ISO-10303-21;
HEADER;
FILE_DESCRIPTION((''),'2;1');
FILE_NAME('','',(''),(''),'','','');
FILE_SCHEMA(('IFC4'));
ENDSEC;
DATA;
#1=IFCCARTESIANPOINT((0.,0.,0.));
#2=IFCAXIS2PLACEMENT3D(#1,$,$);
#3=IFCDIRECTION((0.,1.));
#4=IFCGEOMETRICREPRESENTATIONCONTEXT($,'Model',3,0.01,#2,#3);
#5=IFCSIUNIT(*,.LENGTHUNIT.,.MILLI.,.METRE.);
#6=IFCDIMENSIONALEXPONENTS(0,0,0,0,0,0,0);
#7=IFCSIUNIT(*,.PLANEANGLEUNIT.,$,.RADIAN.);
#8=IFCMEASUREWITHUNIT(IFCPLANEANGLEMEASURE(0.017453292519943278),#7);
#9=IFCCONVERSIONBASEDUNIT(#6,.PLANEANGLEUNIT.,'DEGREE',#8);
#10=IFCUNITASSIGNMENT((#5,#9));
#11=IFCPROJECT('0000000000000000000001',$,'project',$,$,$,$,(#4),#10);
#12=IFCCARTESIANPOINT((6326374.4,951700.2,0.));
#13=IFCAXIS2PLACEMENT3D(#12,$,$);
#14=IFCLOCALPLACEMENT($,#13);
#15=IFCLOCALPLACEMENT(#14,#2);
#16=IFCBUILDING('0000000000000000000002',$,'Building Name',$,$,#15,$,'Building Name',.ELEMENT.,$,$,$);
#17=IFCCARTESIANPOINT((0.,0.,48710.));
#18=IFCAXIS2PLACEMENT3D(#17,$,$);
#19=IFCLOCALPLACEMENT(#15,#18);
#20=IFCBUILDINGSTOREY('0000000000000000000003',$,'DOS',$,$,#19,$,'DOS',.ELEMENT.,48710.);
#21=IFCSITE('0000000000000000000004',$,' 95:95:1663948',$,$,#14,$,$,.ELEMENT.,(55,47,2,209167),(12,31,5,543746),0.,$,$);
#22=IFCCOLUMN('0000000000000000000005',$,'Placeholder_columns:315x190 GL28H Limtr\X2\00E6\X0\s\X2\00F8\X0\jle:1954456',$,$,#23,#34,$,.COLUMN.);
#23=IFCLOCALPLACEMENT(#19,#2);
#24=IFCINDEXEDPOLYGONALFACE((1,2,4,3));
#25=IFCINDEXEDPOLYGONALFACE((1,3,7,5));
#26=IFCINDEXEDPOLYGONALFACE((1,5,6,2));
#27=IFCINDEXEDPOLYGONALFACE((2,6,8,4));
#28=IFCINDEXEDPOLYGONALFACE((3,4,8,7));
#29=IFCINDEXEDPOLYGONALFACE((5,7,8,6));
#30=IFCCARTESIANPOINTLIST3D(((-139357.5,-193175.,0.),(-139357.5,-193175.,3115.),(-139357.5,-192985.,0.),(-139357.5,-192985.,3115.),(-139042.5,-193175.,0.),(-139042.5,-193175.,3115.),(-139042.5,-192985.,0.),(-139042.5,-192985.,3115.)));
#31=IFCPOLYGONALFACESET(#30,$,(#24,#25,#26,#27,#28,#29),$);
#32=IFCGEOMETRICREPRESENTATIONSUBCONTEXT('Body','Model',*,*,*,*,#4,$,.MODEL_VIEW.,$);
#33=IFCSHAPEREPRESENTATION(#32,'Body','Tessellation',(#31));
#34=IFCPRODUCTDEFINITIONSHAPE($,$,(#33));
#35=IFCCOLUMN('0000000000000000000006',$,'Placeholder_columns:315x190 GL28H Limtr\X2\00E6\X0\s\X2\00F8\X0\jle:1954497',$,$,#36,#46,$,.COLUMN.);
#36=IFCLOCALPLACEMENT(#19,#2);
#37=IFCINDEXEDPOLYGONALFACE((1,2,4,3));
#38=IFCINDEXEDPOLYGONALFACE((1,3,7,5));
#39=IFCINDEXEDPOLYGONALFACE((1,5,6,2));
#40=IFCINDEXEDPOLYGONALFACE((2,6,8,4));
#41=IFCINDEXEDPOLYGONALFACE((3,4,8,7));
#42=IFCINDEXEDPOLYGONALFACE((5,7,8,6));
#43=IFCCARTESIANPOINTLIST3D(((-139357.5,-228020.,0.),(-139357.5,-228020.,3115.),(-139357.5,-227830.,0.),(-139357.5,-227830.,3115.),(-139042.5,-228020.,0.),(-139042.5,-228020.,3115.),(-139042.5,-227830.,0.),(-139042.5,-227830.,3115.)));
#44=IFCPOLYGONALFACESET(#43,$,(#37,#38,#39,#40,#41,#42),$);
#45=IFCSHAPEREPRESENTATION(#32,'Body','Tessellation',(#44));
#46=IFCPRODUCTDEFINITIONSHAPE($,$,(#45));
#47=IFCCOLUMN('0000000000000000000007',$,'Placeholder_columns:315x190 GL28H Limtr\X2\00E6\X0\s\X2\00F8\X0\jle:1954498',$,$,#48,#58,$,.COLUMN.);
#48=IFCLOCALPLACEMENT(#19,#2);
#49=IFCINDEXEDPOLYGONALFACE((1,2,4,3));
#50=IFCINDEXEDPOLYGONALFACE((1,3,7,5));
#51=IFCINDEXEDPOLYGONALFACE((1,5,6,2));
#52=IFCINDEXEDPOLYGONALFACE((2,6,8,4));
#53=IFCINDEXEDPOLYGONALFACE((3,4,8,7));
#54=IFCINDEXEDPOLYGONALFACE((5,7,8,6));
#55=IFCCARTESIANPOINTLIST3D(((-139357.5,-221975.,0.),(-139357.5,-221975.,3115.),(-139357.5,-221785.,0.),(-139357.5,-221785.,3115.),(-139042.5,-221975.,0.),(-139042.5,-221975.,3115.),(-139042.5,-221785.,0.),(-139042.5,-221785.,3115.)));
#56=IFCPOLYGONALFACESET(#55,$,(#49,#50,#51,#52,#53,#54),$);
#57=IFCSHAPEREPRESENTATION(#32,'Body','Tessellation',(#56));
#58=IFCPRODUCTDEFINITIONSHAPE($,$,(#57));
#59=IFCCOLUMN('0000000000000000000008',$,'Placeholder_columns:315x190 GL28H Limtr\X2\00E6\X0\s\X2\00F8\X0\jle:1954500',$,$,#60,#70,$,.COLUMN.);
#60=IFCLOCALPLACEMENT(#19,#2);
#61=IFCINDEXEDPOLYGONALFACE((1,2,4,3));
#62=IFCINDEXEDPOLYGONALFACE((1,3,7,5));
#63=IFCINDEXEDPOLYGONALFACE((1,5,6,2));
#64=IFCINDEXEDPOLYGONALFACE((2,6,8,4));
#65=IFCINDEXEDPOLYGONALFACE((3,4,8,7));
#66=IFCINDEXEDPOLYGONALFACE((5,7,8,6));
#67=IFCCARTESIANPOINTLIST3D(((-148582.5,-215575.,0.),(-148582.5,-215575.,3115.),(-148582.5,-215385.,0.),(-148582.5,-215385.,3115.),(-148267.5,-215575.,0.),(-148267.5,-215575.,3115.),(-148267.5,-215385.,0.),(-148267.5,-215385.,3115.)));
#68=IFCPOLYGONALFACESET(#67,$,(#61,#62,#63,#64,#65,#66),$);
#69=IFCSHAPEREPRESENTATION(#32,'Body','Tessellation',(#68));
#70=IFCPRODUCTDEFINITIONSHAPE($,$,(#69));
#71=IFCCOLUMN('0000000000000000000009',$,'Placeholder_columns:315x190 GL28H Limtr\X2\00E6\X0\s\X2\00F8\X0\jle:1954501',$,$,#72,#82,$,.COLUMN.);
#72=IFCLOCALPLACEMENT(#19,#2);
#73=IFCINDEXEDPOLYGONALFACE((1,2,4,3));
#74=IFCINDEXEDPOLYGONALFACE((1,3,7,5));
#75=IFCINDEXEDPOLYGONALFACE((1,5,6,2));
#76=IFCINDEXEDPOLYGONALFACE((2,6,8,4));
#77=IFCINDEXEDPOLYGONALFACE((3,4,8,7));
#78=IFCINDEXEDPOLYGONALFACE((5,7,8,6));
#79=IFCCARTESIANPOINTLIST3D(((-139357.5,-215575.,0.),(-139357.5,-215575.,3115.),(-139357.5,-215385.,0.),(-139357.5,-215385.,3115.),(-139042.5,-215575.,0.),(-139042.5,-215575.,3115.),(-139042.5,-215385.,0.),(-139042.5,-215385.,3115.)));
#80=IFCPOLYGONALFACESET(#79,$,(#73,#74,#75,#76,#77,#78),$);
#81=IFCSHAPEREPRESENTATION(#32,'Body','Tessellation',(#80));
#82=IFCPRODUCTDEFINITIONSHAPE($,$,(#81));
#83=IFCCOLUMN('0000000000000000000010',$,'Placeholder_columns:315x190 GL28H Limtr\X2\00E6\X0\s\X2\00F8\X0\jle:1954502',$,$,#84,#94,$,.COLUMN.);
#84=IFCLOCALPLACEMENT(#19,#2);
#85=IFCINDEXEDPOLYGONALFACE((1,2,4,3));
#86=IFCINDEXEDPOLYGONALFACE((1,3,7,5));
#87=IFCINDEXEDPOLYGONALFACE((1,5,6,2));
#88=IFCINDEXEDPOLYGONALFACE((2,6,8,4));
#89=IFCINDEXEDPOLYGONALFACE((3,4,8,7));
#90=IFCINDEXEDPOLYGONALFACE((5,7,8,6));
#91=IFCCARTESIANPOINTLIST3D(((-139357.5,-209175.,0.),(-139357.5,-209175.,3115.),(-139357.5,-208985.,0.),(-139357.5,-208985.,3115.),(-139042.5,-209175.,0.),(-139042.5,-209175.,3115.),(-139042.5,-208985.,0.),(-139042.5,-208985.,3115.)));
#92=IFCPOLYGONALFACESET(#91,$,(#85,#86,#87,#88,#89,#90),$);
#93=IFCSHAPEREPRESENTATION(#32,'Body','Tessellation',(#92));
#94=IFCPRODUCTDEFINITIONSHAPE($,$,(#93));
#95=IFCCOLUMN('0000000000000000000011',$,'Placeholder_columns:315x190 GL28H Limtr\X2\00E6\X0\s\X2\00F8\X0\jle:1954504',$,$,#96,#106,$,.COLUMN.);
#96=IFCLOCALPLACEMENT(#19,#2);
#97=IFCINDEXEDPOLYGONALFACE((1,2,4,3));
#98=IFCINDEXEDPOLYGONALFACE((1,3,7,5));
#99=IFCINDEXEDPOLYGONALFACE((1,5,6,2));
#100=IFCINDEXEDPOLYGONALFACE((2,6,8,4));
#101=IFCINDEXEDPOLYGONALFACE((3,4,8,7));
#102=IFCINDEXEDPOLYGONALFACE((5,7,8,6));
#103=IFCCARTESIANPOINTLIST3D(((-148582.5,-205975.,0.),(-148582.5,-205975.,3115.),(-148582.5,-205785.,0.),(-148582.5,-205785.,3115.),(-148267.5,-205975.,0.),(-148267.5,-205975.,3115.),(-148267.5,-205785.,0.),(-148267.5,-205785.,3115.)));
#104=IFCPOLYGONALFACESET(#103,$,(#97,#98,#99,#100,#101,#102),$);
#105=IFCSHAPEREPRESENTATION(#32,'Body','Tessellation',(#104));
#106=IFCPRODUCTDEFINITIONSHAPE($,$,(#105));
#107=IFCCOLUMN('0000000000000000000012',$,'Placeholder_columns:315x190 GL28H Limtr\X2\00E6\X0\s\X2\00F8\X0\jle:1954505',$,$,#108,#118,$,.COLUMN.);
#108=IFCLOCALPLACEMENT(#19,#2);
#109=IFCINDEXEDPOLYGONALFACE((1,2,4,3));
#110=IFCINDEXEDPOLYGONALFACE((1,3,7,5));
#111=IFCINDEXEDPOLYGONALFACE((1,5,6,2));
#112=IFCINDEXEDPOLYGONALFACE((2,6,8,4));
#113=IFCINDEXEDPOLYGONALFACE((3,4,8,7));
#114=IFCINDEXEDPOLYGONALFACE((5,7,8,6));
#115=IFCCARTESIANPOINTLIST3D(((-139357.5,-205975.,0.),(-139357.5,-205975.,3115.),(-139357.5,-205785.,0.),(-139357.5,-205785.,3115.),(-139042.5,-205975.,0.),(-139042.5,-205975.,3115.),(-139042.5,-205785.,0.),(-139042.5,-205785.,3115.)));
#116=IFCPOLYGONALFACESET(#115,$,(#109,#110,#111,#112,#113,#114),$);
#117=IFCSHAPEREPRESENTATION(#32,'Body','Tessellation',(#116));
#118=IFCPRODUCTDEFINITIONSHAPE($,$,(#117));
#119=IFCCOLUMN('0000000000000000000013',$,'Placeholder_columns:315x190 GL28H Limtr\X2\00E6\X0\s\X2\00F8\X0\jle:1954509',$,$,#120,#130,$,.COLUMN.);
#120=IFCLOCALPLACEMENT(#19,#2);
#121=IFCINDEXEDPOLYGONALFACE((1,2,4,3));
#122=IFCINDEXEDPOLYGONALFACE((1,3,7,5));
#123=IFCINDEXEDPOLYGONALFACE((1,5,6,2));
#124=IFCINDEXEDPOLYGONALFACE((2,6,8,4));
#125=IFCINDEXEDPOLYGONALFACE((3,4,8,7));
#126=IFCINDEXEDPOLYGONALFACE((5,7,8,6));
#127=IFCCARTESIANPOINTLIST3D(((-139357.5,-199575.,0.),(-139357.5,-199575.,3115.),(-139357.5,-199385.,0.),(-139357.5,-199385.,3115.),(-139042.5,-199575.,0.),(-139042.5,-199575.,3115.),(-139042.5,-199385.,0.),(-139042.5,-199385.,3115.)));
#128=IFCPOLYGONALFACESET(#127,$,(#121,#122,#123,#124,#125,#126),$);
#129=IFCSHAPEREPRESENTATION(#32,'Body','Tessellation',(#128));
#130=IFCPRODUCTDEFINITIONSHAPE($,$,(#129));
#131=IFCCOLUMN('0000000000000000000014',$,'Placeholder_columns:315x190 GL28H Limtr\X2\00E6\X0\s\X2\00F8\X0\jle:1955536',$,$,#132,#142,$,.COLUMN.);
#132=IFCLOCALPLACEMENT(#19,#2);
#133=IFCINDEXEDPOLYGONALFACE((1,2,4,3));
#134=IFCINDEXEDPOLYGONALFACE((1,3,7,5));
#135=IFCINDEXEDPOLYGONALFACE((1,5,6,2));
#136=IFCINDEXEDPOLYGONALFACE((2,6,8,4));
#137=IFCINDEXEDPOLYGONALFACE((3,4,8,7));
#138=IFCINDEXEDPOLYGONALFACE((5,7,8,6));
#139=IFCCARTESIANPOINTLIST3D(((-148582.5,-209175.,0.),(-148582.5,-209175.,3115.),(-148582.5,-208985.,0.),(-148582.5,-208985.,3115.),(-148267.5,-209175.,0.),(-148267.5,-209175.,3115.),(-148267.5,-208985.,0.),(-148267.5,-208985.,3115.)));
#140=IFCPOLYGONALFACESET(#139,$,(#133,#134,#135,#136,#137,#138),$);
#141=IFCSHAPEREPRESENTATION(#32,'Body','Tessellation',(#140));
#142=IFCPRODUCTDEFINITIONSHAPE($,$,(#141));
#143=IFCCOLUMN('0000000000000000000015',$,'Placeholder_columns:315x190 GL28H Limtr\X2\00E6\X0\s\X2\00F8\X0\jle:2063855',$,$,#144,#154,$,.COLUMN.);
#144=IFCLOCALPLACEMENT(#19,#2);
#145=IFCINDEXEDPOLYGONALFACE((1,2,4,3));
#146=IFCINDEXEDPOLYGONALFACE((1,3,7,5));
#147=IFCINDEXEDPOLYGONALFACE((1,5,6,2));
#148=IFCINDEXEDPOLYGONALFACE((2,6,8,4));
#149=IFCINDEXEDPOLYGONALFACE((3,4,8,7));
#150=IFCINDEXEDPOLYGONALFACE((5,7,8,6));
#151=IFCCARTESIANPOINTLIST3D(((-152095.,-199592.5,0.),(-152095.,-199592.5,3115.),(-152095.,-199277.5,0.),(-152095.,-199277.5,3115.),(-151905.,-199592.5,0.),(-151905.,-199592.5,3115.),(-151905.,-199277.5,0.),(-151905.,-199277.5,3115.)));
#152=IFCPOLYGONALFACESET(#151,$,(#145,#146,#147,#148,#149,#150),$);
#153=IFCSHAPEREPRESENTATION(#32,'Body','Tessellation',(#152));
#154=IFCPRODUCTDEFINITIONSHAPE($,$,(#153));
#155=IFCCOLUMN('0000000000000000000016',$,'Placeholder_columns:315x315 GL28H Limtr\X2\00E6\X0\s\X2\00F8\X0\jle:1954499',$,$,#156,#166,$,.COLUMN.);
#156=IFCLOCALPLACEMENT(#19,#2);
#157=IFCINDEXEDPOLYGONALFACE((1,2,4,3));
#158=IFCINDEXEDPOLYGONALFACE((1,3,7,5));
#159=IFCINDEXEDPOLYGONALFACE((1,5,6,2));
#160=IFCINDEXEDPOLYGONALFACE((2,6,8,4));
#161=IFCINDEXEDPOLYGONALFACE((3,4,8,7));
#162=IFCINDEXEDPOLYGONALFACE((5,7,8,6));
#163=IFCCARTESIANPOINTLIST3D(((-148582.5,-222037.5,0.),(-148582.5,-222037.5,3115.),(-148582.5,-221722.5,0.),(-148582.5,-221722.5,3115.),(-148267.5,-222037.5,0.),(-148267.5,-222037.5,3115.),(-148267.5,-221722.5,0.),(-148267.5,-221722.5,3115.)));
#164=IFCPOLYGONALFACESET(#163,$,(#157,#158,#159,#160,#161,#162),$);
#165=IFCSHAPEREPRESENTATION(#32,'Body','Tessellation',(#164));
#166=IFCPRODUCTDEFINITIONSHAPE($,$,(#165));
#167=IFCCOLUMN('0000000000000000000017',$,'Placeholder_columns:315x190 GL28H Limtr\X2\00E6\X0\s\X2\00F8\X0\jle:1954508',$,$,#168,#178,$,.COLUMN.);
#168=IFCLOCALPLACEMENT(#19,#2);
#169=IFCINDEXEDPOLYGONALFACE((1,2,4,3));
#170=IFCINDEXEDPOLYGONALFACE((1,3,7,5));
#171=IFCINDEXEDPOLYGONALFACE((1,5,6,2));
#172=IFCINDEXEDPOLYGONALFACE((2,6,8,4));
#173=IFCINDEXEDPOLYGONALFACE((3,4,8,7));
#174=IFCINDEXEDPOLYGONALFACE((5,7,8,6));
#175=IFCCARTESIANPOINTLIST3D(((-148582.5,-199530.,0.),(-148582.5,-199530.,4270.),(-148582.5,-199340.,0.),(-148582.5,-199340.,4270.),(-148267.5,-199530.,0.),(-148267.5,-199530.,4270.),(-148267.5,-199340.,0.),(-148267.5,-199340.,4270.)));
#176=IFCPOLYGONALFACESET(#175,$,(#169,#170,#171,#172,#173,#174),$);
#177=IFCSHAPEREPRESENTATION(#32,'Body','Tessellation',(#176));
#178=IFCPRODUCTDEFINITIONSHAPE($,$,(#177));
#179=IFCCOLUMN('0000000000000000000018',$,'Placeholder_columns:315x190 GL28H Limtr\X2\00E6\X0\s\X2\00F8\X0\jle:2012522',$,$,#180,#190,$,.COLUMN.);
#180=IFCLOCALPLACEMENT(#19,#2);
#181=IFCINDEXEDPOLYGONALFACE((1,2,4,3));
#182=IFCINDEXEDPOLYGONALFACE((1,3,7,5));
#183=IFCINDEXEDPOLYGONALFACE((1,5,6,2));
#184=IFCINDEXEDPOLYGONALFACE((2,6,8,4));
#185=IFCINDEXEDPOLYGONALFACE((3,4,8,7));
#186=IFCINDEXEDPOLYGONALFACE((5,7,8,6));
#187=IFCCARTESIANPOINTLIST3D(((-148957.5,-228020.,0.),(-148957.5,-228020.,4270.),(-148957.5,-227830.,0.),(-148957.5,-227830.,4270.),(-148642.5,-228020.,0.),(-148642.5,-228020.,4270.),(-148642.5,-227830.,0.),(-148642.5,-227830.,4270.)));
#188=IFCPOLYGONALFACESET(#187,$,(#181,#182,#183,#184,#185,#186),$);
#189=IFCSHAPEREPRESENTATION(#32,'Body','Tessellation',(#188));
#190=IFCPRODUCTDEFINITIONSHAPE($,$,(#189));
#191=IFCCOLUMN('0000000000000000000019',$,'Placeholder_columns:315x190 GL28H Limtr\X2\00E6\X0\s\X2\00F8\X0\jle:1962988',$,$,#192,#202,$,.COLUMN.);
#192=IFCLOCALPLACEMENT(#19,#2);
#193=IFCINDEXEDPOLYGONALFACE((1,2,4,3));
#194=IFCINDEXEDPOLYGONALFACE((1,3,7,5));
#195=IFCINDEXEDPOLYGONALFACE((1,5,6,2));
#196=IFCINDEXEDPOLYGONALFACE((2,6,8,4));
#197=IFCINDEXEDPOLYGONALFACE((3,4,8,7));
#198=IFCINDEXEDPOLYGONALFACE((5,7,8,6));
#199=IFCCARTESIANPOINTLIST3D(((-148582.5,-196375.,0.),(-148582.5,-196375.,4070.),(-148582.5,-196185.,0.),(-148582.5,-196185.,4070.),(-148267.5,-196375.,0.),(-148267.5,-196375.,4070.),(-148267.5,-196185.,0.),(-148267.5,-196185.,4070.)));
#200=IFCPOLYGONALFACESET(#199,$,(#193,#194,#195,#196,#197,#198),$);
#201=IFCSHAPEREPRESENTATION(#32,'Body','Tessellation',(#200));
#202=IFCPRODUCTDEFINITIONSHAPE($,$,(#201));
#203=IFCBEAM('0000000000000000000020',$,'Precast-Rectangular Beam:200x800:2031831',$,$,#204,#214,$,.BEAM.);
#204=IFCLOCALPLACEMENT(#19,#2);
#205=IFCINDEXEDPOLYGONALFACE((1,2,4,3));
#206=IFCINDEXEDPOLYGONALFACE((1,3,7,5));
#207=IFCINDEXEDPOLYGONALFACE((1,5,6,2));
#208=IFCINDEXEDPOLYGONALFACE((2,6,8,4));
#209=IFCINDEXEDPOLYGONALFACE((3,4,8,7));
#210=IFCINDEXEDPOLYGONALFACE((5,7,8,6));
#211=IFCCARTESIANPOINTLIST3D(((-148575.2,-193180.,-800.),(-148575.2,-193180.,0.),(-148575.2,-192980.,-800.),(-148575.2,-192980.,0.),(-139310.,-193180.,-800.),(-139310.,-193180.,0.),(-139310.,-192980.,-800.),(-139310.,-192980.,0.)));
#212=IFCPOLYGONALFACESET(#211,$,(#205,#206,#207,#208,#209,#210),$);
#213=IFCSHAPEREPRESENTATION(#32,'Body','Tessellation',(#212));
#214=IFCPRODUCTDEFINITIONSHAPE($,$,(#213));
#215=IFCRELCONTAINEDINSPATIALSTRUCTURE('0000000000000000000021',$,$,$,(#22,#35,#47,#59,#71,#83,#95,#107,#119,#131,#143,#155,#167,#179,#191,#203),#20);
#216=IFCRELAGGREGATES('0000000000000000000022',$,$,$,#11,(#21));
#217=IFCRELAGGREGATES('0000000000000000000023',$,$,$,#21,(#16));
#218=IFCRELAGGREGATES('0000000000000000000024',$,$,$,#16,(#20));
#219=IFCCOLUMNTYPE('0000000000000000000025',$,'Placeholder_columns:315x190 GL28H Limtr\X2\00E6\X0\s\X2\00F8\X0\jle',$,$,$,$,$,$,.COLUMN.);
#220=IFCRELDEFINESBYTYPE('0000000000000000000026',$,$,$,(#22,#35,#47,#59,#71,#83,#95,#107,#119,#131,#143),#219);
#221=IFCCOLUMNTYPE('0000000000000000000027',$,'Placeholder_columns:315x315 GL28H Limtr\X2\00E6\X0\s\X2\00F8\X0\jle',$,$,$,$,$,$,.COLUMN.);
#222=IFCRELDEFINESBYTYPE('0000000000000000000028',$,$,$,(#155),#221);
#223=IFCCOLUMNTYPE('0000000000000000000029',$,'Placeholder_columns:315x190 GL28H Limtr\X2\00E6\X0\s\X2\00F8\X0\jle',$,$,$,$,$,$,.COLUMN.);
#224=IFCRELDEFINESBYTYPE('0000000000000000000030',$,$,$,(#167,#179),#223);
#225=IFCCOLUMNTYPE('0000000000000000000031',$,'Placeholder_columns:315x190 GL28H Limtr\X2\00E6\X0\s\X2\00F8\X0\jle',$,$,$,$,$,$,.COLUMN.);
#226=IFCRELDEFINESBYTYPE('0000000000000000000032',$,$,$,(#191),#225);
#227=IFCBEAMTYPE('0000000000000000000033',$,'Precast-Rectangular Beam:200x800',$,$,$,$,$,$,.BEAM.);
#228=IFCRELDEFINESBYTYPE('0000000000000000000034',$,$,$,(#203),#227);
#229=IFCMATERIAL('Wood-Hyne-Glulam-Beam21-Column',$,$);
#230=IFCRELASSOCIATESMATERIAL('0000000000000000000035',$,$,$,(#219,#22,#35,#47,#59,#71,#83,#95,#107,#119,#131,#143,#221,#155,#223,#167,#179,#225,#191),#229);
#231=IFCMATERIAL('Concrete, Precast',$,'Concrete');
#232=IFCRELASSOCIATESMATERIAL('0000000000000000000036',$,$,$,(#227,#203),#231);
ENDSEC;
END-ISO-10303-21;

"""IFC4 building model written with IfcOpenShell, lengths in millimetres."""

from ifc_helpers import new_model, entity, si_unit, converted_unit, direction, frame, origin, place, context, subcontext, project, spatial, indexed_curve, outline, extrude, source, transform, mapped, material, type_object, type_shapes, element, save


model = new_model("IFC4")

# Units and contexts
model_context = context("Model", 3, precision=0.01, world=origin(), true_north=direction((0.0, 1.0)))
body_context = subcontext(model_context, "Body", "Model", "MODEL_VIEW")
ifc_project = project(units=[si_unit("LENGTHUNIT", "METRE", prefix="MILLI"), converted_unit("PLANEANGLEUNIT", "DEGREE", entity("IfcPlaneAngleMeasure", 0.017453292519943278), si_unit("PLANEANGLEUNIT", "RADIAN"), dimensions=[0, 0, 0, 0, 0, 0, 0])], contexts=[model_context])

# Site, building, storey
site_placement = place(None, frame((6326374.4, 951700.2, 0.0)))
site = spatial("IfcSite", under=ifc_project, at=site_placement, Name=" 95:95:1663948", CompositionType="ELEMENT", RefLatitude=(55, 47, 2, 209167), RefLongitude=(12, 31, 5, 543746), RefElevation=0.0)
building_placement = place(site_placement, origin())
building = spatial("IfcBuilding", under=site, at=building_placement, Name="Building Name", LongName="Building Name", CompositionType="ELEMENT")
storey_placement = place(building_placement, frame((0.0, 0.0, 48710.0)))
storey = spatial("IfcBuildingStorey", under=building, at=storey_placement, Name="DOS", LongName="DOS", CompositionType="ELEMENT", Elevation=48710.0)

# Columns
ifc_material_1 = material(Name="Wood-Hyne-Glulam-Beam21-Column")
column_type_1 = type_object("IfcColumnType", Name="Placeholder_columns:315x190 GL28H Limtræsøjle", PredefinedType="COLUMN", material=ifc_material_1)
shared_shape_1 = source(origin(), body_context, "Body", "SweptSolid", [
    extrude(outline(indexed_curve([(-157.5, -95.0), (157.5, -95.0), (157.5, 95.0), (-157.5, 95.0), (-157.5, -95.0)], self_intersect=False)), frame((0.0, 0.0, 48710.0), z_axis=(0.0, 0.0, 1.0), x_axis=(-1.0, 0.0, 0.0)), (0.0, 0.0, 1.0), 3115.0),
])
type_shapes(column_type_1, [shared_shape_1])
for number, where, name in (
    (1, (-139200.0, -193080.0, -48710.0), "Placeholder_columns:315x190 GL28H Limtræsøjle:1954456"),
    (2, (-139200.0, -227925.0, -48710.0), "Placeholder_columns:315x190 GL28H Limtræsøjle:1954497"),
    (3, (-139200.0, -221880.0, -48710.0), "Placeholder_columns:315x190 GL28H Limtræsøjle:1954498"),
    (4, (-148425.0, -215480.0, -48710.0), "Placeholder_columns:315x190 GL28H Limtræsøjle:1954500"),
    (5, (-139200.0, -215480.0, -48710.0), "Placeholder_columns:315x190 GL28H Limtræsøjle:1954501"),
    (6, (-139200.0, -209080.0, -48710.0), "Placeholder_columns:315x190 GL28H Limtræsøjle:1954502"),
    (7, (-148425.0, -205880.0, -48710.0), "Placeholder_columns:315x190 GL28H Limtræsøjle:1954504"),
    (8, (-139200.0, -205880.0, -48710.0), "Placeholder_columns:315x190 GL28H Limtræsøjle:1954505"),
    (9, (-139200.0, -199480.0, -48710.0), "Placeholder_columns:315x190 GL28H Limtræsøjle:1954509"),
    (10, (-148425.0, -209080.0, -48710.0), "Placeholder_columns:315x190 GL28H Limtræsøjle:1955536"),
):
    element("IfcColumn", number, at=place(storey_placement, frame(where)), inside=storey, type_object=column_type_1, material=ifc_material_1, Name=name, PredefinedType="COLUMN", context=body_context, shape_type="MappedRepresentation", body=[
        mapped(shared_shape_1, transform((0.0, 0.0, 0.0), scale=1.0)),
    ])
column_1_placement = place(storey_placement, frame((-152000.0, -199435.0, -48710.0), z_axis=(0.0, 0.0, 1.0), x_axis=(0.0, -1.0, 0.0)))
element("IfcColumn", 11, at=column_1_placement, inside=storey, type_object=column_type_1, material=ifc_material_1, Name="Placeholder_columns:315x190 GL28H Limtræsøjle:2063855", PredefinedType="COLUMN", context=body_context, shape_type="MappedRepresentation", body=[
    mapped(shared_shape_1, transform((0.0, 0.0, 0.0), scale=1.0)),
])
column_type_2 = type_object("IfcColumnType", Name="Placeholder_columns:315x315 GL28H Limtræsøjle", PredefinedType="COLUMN", material=ifc_material_1)
shared_shape_2 = source(origin(), body_context, "Body", "SweptSolid", [
    extrude(outline(indexed_curve([(-157.5, -157.5), (157.5, -157.5), (157.5, 157.5), (-157.5, 157.5), (-157.5, -157.5)], self_intersect=False)), frame((0.0, 0.0, 48710.0), z_axis=(0.0, 0.0, 1.0), x_axis=(-1.0, 0.0, 0.0)), (0.0, 0.0, 1.0), 3115.0),
])
type_shapes(column_type_2, [shared_shape_2])
column_2_placement = place(storey_placement, frame((-148425.0, -221880.0, -48710.0)))
element("IfcColumn", 12, at=column_2_placement, inside=storey, type_object=column_type_2, material=ifc_material_1, Name="Placeholder_columns:315x315 GL28H Limtræsøjle:1954499", PredefinedType="COLUMN", context=body_context, shape_type="MappedRepresentation", body=[
    mapped(shared_shape_2, transform((0.0, 0.0, 0.0), scale=1.0)),
])
column_type_3 = type_object("IfcColumnType", Name="Placeholder_columns:315x190 GL28H Limtræsøjle", PredefinedType="COLUMN", material=ifc_material_1)
shared_shape_3 = source(origin(), body_context, "Body", "SweptSolid", [
    extrude(outline(indexed_curve([(-157.5, -95.0), (157.5, -95.0), (157.5, 95.0), (-157.5, 95.0), (-157.5, -95.0)], self_intersect=False)), frame((0.0, 0.0, 48710.0), z_axis=(0.0, 0.0, 1.0), x_axis=(-1.0, 0.0, 0.0)), (0.0, 0.0, 1.0), 4270.0),
])
type_shapes(column_type_3, [shared_shape_3])
for number, where, name in (
    (13, (-148425.0, -199435.0, -48710.0), "Placeholder_columns:315x190 GL28H Limtræsøjle:1954508"),
    (14, (-148800.0, -227925.0, -48710.0), "Placeholder_columns:315x190 GL28H Limtræsøjle:2012522"),
):
    element("IfcColumn", number, at=place(storey_placement, frame(where)), inside=storey, type_object=column_type_3, material=ifc_material_1, Name=name, PredefinedType="COLUMN", context=body_context, shape_type="MappedRepresentation", body=[
        mapped(shared_shape_3, transform((0.0, 0.0, 0.0), scale=1.0)),
    ])
column_type_4 = type_object("IfcColumnType", Name="Placeholder_columns:315x190 GL28H Limtræsøjle", PredefinedType="COLUMN", material=ifc_material_1)
shared_shape_4 = source(origin(), body_context, "Body", "SweptSolid", [
    extrude(outline(indexed_curve([(-157.5, -95.0), (157.5, -95.0), (157.5, 95.0), (-157.5, 95.0), (-157.5, -95.0)], self_intersect=False)), frame((0.0, 0.0, 48710.0), z_axis=(0.0, 0.0, 1.0), x_axis=(-1.0, 0.0, 0.0)), (0.0, 0.0, 1.0), 4070.0),
])
type_shapes(column_type_4, [shared_shape_4])
column_3_placement = place(storey_placement, frame((-148425.0, -196280.0, -48710.0)))
element("IfcColumn", 15, at=column_3_placement, inside=storey, type_object=column_type_4, material=ifc_material_1, Name="Placeholder_columns:315x190 GL28H Limtræsøjle:1962988", PredefinedType="COLUMN", context=body_context, shape_type="MappedRepresentation", body=[
    mapped(shared_shape_4, transform((0.0, 0.0, 0.0), scale=1.0)),
])

# Beam
ifc_material_2 = material(Name="Concrete, Precast", Category="Concrete")
beam_type_1 = type_object("IfcBeamType", Name="Precast-Rectangular Beam:200x800", PredefinedType="BEAM", material=ifc_material_2)
shared_shape_5 = source(origin(), body_context, "Body", "SweptSolid", [
    extrude(outline(indexed_curve([(-4632.6, -100.0), (4632.6, -100.0), (4632.6, 100.0), (-4632.6, 100.0), (-4632.6, -100.0)], self_intersect=False)), frame((-2.6, 0.0, -400.0), z_axis=(0.0, 0.0, 1.0), x_axis=(-1.0, 0.0, 0.0)), (0.0, 0.0, 1.0), 800.0),
])
type_shapes(beam_type_1, [shared_shape_5])
for number, where, name in (
    (16, (-143940.0, -193080.0, -400.0), "Precast-Rectangular Beam:200x800:2031831"),
):
    element("IfcBeam", number, at=place(storey_placement, frame(where)), inside=storey, type_object=beam_type_1, material=ifc_material_2, Name=name, PredefinedType="BEAM", context=body_context, shape_type="MappedRepresentation", body=[
        mapped(shared_shape_5, transform((0.0, 0.0, 0.0), scale=1.0)),
    ])

save(model, "model.ifc")
